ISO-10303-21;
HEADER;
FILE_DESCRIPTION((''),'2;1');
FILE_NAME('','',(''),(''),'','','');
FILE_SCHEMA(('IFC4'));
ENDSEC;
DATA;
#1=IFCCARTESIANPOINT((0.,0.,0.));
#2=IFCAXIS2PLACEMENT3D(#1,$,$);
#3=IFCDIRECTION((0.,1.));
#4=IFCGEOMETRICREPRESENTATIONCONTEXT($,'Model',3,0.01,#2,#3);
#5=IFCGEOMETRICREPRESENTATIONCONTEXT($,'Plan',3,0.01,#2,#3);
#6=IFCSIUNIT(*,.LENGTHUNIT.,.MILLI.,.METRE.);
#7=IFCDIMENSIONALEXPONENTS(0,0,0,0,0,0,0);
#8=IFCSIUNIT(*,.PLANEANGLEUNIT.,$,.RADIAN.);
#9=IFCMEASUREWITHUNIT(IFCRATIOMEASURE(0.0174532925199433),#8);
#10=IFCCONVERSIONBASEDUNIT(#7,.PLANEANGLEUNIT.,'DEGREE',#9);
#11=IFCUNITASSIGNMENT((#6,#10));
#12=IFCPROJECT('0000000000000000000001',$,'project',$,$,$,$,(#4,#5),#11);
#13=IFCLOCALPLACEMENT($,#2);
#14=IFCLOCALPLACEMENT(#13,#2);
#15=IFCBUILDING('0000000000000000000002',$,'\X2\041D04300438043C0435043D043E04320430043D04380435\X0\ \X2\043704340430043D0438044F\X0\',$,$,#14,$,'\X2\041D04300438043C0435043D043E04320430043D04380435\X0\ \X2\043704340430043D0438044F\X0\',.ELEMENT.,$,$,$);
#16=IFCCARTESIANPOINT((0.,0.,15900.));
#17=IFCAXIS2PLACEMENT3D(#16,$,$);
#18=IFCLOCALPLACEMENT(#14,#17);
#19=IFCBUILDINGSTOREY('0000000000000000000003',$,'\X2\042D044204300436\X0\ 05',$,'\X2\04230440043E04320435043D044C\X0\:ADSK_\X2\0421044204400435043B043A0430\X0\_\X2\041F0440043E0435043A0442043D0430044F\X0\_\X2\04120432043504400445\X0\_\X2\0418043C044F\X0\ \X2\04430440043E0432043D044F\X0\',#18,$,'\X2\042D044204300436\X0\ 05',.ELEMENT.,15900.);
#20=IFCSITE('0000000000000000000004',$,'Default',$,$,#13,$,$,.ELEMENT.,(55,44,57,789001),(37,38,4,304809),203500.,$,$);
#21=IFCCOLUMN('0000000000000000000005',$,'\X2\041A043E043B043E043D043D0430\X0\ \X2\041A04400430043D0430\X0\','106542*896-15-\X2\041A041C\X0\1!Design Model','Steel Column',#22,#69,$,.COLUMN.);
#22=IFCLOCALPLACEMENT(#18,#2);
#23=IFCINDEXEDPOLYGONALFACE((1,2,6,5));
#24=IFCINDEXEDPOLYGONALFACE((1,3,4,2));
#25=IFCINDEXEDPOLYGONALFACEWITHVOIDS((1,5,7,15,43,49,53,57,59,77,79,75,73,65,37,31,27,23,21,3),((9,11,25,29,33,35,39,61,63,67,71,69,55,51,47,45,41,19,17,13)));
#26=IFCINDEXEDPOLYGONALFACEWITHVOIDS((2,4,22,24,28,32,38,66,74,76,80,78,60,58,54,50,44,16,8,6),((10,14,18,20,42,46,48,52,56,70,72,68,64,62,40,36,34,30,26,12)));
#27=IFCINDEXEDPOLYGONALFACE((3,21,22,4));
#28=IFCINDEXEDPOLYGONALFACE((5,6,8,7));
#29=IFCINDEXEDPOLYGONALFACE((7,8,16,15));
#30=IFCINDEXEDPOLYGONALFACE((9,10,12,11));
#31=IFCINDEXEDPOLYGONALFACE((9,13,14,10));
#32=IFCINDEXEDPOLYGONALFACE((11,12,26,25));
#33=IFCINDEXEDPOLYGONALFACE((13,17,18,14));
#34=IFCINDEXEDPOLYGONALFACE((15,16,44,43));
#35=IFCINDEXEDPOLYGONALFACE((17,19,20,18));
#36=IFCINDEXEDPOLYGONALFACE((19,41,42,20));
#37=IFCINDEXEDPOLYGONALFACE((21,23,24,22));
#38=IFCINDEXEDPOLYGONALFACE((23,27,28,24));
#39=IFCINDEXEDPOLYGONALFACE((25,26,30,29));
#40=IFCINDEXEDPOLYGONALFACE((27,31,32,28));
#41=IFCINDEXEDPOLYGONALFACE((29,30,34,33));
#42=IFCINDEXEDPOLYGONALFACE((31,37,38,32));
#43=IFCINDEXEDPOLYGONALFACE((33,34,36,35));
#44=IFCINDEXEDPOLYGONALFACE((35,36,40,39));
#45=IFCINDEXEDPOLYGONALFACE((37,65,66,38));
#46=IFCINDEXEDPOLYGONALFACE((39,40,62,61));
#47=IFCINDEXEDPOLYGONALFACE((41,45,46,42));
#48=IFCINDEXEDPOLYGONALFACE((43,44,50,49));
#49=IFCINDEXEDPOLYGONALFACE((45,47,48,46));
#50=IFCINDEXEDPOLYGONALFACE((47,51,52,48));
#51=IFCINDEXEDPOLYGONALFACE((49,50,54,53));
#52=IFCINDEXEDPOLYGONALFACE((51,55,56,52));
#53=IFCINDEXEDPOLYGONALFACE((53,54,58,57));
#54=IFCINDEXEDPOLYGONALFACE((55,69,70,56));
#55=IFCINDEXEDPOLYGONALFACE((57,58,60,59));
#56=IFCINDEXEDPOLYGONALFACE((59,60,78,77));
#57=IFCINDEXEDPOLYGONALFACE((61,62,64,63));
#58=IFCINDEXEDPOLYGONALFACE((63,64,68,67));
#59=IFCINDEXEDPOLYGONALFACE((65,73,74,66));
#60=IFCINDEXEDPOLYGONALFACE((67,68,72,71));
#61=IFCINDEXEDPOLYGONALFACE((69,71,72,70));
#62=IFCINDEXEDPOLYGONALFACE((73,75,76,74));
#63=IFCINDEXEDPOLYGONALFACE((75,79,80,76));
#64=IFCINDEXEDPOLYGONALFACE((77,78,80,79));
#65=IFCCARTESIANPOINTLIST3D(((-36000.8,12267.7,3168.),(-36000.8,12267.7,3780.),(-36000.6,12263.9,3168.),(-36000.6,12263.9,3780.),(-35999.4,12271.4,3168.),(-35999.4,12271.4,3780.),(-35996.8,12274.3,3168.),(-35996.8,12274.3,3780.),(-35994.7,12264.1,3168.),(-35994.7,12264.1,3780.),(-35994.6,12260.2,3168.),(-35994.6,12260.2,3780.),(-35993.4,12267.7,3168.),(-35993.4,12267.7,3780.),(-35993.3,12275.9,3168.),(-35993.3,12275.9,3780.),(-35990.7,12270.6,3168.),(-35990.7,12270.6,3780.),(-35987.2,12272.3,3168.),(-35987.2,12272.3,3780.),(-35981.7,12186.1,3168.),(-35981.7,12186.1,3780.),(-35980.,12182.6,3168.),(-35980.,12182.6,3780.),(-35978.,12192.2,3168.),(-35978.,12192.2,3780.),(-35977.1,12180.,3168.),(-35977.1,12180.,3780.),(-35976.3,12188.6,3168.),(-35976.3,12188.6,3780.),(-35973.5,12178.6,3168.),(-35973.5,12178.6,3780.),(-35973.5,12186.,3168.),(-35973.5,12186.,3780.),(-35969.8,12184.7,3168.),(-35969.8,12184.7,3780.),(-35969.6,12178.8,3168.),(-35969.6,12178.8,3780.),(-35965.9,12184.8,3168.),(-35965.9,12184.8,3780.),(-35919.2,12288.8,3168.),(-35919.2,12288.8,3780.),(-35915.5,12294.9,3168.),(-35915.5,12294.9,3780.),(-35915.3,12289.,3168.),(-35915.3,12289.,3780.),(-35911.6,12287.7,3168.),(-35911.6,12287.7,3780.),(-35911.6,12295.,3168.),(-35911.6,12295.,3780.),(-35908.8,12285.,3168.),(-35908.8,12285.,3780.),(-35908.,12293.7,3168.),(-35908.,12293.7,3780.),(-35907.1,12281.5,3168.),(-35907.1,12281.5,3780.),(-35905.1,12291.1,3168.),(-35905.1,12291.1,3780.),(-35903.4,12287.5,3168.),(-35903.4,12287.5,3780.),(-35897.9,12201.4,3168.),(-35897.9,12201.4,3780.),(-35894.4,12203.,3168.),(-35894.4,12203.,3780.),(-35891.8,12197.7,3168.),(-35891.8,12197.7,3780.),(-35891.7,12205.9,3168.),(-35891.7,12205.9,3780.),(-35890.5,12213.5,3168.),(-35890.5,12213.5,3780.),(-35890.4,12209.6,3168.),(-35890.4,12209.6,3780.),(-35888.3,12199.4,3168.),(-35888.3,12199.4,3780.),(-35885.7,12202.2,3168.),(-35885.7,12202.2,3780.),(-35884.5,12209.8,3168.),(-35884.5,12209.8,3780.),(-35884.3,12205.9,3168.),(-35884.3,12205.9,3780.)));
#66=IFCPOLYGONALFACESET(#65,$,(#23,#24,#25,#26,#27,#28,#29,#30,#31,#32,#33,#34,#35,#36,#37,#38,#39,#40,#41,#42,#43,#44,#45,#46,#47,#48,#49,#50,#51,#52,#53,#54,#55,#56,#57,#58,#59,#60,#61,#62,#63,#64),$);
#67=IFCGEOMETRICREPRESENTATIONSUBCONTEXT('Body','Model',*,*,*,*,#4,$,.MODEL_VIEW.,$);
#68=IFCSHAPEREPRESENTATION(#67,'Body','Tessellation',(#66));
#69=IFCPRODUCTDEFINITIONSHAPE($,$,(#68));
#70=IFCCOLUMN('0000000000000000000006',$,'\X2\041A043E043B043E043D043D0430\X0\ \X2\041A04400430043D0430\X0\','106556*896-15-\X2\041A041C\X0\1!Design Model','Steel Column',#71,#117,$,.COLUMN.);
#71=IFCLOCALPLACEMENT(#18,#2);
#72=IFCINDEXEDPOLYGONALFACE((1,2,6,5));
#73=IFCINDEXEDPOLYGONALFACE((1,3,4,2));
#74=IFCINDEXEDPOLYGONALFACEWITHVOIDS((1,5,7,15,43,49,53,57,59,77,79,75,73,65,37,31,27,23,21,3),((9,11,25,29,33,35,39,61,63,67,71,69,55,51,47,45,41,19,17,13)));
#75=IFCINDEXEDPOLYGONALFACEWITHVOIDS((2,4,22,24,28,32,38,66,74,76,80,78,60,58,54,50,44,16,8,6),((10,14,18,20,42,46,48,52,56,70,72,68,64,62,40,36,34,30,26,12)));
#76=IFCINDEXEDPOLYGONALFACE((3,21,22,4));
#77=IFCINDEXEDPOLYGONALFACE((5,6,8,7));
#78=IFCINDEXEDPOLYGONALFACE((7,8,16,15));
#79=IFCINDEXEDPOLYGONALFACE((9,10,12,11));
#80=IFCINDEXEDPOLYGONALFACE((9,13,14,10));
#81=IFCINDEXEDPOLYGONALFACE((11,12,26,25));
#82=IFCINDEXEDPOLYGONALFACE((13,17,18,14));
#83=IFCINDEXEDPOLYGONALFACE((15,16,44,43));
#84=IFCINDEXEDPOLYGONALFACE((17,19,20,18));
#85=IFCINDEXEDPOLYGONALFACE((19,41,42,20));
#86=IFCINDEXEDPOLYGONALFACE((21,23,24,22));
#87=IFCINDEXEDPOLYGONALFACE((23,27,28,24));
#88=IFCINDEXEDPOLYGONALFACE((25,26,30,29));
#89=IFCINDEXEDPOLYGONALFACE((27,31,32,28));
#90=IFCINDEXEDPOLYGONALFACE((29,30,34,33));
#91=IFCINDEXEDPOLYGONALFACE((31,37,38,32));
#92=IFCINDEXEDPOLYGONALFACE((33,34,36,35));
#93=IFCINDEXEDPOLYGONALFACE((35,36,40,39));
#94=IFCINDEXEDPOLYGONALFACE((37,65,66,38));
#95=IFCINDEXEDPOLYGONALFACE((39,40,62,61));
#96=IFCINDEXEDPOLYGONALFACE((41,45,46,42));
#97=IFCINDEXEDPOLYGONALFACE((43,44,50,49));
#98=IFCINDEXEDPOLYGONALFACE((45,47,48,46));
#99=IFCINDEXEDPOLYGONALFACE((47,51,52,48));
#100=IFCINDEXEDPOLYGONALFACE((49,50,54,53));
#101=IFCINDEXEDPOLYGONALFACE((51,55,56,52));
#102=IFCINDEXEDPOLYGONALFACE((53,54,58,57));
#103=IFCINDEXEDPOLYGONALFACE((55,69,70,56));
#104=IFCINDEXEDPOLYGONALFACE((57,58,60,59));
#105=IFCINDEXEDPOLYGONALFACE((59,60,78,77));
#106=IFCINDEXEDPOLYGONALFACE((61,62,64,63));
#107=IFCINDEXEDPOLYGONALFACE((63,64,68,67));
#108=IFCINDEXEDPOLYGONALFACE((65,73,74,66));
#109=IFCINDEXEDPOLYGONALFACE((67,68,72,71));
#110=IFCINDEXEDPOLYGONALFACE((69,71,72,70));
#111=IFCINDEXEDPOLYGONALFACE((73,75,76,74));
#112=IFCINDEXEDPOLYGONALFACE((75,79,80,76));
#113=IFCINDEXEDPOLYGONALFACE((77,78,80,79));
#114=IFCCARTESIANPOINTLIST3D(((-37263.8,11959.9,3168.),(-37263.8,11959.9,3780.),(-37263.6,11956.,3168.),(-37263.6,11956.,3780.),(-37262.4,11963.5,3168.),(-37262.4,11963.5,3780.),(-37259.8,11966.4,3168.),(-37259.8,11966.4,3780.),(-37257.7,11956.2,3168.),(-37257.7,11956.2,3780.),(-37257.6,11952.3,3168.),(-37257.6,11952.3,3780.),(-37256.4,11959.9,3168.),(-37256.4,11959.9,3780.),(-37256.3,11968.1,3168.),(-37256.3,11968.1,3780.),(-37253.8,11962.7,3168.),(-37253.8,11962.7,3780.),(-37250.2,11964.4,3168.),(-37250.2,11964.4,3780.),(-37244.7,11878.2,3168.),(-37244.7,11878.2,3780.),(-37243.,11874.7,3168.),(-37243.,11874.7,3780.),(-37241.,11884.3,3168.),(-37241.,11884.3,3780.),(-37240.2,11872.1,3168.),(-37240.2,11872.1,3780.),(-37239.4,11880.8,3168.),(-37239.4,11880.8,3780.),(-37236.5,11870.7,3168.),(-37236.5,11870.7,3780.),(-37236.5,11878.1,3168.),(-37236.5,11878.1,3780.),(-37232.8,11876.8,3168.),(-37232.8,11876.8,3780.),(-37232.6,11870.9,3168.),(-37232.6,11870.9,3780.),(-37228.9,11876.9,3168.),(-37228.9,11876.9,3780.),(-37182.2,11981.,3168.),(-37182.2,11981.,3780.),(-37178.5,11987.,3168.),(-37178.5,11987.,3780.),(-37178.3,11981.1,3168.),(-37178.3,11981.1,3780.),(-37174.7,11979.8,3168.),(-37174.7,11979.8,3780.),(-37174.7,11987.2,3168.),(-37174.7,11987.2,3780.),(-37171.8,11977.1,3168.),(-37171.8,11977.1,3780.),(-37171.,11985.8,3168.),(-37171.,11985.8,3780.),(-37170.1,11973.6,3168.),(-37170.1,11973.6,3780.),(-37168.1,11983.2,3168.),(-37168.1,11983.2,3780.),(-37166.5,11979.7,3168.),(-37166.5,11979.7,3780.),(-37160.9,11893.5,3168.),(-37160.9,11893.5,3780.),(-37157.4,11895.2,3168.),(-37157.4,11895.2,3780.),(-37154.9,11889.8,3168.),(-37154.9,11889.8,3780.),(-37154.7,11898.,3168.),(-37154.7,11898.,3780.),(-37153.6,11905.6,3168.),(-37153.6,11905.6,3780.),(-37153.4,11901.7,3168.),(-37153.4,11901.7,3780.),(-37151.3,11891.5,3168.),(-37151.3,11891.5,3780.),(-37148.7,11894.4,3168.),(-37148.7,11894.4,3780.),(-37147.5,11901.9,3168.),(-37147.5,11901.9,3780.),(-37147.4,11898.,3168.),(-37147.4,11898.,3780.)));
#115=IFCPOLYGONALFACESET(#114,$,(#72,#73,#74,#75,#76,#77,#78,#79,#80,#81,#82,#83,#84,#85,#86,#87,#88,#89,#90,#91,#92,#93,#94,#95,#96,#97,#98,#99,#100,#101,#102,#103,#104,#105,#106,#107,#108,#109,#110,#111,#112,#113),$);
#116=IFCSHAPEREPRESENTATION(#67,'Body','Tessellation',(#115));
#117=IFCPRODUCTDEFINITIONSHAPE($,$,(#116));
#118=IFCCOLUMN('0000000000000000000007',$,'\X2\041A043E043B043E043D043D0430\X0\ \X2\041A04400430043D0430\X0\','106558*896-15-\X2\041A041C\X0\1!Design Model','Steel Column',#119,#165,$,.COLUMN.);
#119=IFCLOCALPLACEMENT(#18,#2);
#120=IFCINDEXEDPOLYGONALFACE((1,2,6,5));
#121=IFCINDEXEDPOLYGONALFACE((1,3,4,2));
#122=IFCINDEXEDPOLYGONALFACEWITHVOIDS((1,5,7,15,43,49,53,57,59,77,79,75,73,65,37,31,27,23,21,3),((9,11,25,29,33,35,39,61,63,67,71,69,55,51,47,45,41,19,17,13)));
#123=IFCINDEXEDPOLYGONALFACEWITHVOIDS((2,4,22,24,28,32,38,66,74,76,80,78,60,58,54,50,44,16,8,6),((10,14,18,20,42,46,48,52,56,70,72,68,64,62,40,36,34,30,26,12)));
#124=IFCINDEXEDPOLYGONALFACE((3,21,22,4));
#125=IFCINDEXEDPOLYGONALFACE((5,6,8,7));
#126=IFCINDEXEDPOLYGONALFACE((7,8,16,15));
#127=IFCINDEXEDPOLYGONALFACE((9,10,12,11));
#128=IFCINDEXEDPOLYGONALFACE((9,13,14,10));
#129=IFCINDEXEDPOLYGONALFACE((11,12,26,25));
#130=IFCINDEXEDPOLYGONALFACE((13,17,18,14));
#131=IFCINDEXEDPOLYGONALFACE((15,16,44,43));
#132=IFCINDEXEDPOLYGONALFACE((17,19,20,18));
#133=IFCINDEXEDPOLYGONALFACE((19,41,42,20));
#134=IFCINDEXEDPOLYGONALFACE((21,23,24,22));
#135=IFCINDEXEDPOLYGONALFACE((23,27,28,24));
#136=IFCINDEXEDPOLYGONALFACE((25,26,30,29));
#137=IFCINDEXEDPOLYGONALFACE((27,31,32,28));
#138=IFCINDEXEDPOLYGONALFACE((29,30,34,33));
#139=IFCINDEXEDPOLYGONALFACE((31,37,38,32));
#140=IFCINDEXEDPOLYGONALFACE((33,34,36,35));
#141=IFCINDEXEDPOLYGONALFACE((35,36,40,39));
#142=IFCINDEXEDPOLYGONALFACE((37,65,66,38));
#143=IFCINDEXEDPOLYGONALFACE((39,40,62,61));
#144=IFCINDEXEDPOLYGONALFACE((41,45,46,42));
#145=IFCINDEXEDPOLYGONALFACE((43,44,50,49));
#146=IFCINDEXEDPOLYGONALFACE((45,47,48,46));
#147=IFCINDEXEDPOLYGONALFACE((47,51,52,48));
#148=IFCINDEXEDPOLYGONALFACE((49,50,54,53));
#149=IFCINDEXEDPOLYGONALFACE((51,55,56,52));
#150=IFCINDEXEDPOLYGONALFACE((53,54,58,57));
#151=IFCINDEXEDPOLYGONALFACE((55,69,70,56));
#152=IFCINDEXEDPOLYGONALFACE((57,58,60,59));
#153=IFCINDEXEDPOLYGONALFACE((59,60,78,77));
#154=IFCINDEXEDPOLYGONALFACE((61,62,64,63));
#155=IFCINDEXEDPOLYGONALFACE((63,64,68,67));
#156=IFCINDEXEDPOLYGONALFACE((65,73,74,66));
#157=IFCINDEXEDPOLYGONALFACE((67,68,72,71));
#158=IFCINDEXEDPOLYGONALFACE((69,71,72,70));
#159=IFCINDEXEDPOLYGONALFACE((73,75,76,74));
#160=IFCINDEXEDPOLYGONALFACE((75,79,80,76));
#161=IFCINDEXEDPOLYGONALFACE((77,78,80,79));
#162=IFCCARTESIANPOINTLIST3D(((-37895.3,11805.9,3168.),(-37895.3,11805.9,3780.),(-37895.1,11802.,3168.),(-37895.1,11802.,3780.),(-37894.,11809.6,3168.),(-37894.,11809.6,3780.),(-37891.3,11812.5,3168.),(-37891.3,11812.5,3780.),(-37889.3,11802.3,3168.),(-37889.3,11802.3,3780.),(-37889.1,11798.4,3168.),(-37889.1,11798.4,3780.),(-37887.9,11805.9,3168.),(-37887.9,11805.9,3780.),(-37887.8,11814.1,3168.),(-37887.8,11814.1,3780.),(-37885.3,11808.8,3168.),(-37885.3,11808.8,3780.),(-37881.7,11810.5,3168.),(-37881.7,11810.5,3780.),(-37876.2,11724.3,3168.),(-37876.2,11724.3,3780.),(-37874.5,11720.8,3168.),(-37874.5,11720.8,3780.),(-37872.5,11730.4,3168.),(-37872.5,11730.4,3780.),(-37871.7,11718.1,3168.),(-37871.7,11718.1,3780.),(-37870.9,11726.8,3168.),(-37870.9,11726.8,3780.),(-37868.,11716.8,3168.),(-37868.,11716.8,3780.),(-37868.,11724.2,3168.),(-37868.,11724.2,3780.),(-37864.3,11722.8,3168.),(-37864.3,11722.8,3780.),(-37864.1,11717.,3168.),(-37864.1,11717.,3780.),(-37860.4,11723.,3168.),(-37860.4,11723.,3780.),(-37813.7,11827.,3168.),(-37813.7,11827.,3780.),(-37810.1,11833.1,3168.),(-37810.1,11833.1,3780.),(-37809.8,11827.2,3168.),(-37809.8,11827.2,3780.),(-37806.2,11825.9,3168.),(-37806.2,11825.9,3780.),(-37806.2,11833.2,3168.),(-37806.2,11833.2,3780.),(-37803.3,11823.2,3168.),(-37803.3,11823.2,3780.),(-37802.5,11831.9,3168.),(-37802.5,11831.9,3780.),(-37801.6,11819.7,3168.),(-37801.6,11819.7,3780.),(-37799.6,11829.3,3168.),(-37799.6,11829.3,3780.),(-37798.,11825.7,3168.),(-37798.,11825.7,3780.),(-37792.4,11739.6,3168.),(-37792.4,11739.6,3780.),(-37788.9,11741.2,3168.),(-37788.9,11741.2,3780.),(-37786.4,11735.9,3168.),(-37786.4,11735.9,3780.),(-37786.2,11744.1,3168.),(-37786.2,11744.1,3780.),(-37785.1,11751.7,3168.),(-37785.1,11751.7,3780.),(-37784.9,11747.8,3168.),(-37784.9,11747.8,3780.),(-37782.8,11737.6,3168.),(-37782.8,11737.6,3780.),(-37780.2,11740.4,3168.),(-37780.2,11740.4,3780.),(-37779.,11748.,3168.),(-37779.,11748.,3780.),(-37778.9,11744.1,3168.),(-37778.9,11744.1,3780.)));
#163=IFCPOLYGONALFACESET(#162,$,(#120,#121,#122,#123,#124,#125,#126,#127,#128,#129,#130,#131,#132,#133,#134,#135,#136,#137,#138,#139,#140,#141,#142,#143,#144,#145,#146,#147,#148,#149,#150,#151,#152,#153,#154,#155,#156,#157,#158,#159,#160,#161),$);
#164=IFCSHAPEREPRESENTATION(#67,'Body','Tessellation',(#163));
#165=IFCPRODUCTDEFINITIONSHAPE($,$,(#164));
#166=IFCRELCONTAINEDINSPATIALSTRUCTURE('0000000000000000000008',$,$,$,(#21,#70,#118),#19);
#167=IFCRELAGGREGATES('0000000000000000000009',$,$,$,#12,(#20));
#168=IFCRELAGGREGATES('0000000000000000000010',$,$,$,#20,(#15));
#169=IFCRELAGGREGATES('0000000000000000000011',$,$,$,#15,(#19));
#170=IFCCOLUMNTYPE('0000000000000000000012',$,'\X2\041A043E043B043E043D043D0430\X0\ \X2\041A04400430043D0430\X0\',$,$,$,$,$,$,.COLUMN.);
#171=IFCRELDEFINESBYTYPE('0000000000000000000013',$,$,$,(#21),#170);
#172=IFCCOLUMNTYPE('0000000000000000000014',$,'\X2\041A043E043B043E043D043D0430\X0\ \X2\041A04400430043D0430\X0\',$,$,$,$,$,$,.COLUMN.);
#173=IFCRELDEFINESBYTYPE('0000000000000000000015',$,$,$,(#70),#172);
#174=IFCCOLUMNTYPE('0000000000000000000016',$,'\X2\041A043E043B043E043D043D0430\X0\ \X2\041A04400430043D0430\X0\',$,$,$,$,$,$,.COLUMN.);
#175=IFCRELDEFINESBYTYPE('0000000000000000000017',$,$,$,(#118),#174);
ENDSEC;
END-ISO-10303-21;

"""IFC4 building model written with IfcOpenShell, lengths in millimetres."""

from ifc_helpers import new_model, entity, si_unit, converted_unit, direction, frame, origin, place, context, subcontext, project, spatial, indexed_curve, outline, extrude, type_object, element, save


model = new_model("IFC4")

# Units and contexts
model_context = context("Model", 3, precision=0.01, world=origin(), true_north=direction((0.0, 1.0)))
plan_context = context("Plan", 3, precision=0.01, world=origin(), true_north=direction((0.0, 1.0)))
body_context = subcontext(model_context, "Body", "Model", "MODEL_VIEW")
ifc_project = project(units=[si_unit("LENGTHUNIT", "METRE", prefix="MILLI"), converted_unit("PLANEANGLEUNIT", "DEGREE", entity("IfcRatioMeasure", 0.0174532925199433), si_unit("PLANEANGLEUNIT", "RADIAN"), dimensions=[0, 0, 0, 0, 0, 0, 0])], contexts=[model_context, plan_context])

# Site, building, storey
site_placement = place(None, origin())
site = spatial("IfcSite", under=ifc_project, at=site_placement, Name="Default", CompositionType="ELEMENT", RefLatitude=(55, 44, 57, 789001), RefLongitude=(37, 38, 4, 304809), RefElevation=203500.0)
building_placement = place(site_placement, origin())
building = spatial("IfcBuilding", under=site, at=building_placement, Name="Наименование здания", LongName="Наименование здания", CompositionType="ELEMENT")
storey_placement = place(building_placement, frame((0.0, 0.0, 15900.0)))
storey = spatial("IfcBuildingStorey", under=building, at=storey_placement, Name="Этаж 05", ObjectType="Уровень:ADSK_Стрелка_Проектная_Вверх_Имя уровня", LongName="Этаж 05", CompositionType="ELEMENT", Elevation=15900.0)

# Columns
placement = place(storey_placement, origin())
column_type_1 = type_object("IfcColumnType", Name="Колонна Крана", PredefinedType="COLUMN")
element("IfcColumn", 1, at=placement, inside=storey, type_object=column_type_1, Name="Колонна Крана", Description="106542*896-15-КМ1!Design Model", ObjectType="Steel Column", PredefinedType="COLUMN", context=body_context, shape_type="SweptSolid", body=[
    extrude(outline(indexed_curve([(29.5, -56.8), (33.4, -56.8), (37.0, -55.3), (39.7, -52.6), (41.2, -49.0), (56.8, 29.5), (56.8, 33.4), (55.3, 37.0), (52.6, 39.7), (49.0, 41.2), (-29.5, 56.8), (-33.4, 56.8), (-37.0, 55.3), (-39.7, 52.6), (-41.2, 49.0), (-56.8, -29.5), (-56.8, -33.4), (-55.3, -37.0), (-52.6, -39.7), (-49.0, -41.2), (29.5, -56.8)], self_intersect=False), holes=[indexed_curve([(-43.1, -37.3), (-46.7, -35.8), (-49.5, -33.1), (-51.0, -29.5), (-51.0, -25.5), (-37.3, 43.1), (-35.8, 46.7), (-33.1, 49.5), (-29.5, 51.0), (-25.5, 51.0), (43.1, 37.3), (46.7, 35.8), (49.5, 33.1), (51.0, 29.5), (51.0, 25.5), (37.3, -43.1), (35.8, -46.7), (33.1, -49.5), (29.5, -51.0), (25.5, -51.0), (-43.1, -37.3)], self_intersect=False)]), frame((-35942.6, 12236.8, 3168.0), z_axis=(0.0, 0.0, 1.0), x_axis=(0.906681, 0.421816, 0.0)), (0.0, 0.0, 1.0), 612.0),
])
column_type_2 = type_object("IfcColumnType", Name="Колонна Крана", PredefinedType="COLUMN")
element("IfcColumn", 2, at=placement, inside=storey, type_object=column_type_2, Name="Колонна Крана", Description="106556*896-15-КМ1!Design Model", ObjectType="Steel Column", PredefinedType="COLUMN", context=body_context, shape_type="SweptSolid", body=[
    extrude(outline(indexed_curve([(29.5, -56.8), (33.4, -56.8), (37.0, -55.3), (39.7, -52.6), (41.2, -49.0), (56.8, 29.5), (56.8, 33.4), (55.3, 37.0), (52.6, 39.7), (49.0, 41.2), (-29.5, 56.8), (-33.4, 56.8), (-37.0, 55.3), (-39.7, 52.6), (-41.2, 49.0), (-56.8, -29.5), (-56.8, -33.4), (-55.3, -37.0), (-52.6, -39.7), (-49.0, -41.2), (29.5, -56.8)], self_intersect=False), holes=[indexed_curve([(-43.1, -37.3), (-46.7, -35.8), (-49.5, -33.1), (-51.0, -29.5), (-51.0, -25.5), (-37.3, 43.1), (-35.8, 46.7), (-33.1, 49.5), (-29.5, 51.0), (-25.5, 51.0), (43.1, 37.3), (46.7, 35.8), (49.5, 33.1), (51.0, 29.5), (51.0, 25.5), (37.3, -43.1), (35.8, -46.7), (33.1, -49.5), (29.5, -51.0), (25.5, -51.0), (-43.1, -37.3)], self_intersect=False)]), frame((-37205.6, 11929.0, 3168.0), z_axis=(0.0, 0.0, 1.0), x_axis=(0.906681, 0.421816, 0.0)), (0.0, 0.0, 1.0), 612.0),
])
column_type_3 = type_object("IfcColumnType", Name="Колонна Крана", PredefinedType="COLUMN")
element("IfcColumn", 3, at=placement, inside=storey, type_object=column_type_3, Name="Колонна Крана", Description="106558*896-15-КМ1!Design Model", ObjectType="Steel Column", PredefinedType="COLUMN", context=body_context, shape_type="SweptSolid", body=[
    extrude(outline(indexed_curve([(29.5, -56.8), (33.4, -56.8), (37.0, -55.3), (39.7, -52.6), (41.2, -49.0), (56.8, 29.5), (56.8, 33.4), (55.3, 37.0), (52.6, 39.7), (49.0, 41.2), (-29.5, 56.8), (-33.4, 56.8), (-37.0, 55.3), (-39.7, 52.6), (-41.2, 49.0), (-56.8, -29.5), (-56.8, -33.4), (-55.3, -37.0), (-52.6, -39.7), (-49.0, -41.2), (29.5, -56.8)], self_intersect=False), holes=[indexed_curve([(-43.1, -37.3), (-46.7, -35.8), (-49.5, -33.1), (-51.0, -29.5), (-51.0, -25.5), (-37.3, 43.1), (-35.8, 46.7), (-33.1, 49.5), (-29.5, 51.0), (-25.5, 51.0), (43.1, 37.3), (46.7, 35.8), (49.5, 33.1), (51.0, 29.5), (51.0, 25.5), (37.3, -43.1), (35.8, -46.7), (33.1, -49.5), (29.5, -51.0), (25.5, -51.0), (-43.1, -37.3)], self_intersect=False)]), frame((-37837.1, 11775.0, 3168.0), z_axis=(0.0, 0.0, 1.0), x_axis=(0.906681, 0.421816, 0.0)), (0.0, 0.0, 1.0), 612.0),
])

save(model, "model.ifc")
